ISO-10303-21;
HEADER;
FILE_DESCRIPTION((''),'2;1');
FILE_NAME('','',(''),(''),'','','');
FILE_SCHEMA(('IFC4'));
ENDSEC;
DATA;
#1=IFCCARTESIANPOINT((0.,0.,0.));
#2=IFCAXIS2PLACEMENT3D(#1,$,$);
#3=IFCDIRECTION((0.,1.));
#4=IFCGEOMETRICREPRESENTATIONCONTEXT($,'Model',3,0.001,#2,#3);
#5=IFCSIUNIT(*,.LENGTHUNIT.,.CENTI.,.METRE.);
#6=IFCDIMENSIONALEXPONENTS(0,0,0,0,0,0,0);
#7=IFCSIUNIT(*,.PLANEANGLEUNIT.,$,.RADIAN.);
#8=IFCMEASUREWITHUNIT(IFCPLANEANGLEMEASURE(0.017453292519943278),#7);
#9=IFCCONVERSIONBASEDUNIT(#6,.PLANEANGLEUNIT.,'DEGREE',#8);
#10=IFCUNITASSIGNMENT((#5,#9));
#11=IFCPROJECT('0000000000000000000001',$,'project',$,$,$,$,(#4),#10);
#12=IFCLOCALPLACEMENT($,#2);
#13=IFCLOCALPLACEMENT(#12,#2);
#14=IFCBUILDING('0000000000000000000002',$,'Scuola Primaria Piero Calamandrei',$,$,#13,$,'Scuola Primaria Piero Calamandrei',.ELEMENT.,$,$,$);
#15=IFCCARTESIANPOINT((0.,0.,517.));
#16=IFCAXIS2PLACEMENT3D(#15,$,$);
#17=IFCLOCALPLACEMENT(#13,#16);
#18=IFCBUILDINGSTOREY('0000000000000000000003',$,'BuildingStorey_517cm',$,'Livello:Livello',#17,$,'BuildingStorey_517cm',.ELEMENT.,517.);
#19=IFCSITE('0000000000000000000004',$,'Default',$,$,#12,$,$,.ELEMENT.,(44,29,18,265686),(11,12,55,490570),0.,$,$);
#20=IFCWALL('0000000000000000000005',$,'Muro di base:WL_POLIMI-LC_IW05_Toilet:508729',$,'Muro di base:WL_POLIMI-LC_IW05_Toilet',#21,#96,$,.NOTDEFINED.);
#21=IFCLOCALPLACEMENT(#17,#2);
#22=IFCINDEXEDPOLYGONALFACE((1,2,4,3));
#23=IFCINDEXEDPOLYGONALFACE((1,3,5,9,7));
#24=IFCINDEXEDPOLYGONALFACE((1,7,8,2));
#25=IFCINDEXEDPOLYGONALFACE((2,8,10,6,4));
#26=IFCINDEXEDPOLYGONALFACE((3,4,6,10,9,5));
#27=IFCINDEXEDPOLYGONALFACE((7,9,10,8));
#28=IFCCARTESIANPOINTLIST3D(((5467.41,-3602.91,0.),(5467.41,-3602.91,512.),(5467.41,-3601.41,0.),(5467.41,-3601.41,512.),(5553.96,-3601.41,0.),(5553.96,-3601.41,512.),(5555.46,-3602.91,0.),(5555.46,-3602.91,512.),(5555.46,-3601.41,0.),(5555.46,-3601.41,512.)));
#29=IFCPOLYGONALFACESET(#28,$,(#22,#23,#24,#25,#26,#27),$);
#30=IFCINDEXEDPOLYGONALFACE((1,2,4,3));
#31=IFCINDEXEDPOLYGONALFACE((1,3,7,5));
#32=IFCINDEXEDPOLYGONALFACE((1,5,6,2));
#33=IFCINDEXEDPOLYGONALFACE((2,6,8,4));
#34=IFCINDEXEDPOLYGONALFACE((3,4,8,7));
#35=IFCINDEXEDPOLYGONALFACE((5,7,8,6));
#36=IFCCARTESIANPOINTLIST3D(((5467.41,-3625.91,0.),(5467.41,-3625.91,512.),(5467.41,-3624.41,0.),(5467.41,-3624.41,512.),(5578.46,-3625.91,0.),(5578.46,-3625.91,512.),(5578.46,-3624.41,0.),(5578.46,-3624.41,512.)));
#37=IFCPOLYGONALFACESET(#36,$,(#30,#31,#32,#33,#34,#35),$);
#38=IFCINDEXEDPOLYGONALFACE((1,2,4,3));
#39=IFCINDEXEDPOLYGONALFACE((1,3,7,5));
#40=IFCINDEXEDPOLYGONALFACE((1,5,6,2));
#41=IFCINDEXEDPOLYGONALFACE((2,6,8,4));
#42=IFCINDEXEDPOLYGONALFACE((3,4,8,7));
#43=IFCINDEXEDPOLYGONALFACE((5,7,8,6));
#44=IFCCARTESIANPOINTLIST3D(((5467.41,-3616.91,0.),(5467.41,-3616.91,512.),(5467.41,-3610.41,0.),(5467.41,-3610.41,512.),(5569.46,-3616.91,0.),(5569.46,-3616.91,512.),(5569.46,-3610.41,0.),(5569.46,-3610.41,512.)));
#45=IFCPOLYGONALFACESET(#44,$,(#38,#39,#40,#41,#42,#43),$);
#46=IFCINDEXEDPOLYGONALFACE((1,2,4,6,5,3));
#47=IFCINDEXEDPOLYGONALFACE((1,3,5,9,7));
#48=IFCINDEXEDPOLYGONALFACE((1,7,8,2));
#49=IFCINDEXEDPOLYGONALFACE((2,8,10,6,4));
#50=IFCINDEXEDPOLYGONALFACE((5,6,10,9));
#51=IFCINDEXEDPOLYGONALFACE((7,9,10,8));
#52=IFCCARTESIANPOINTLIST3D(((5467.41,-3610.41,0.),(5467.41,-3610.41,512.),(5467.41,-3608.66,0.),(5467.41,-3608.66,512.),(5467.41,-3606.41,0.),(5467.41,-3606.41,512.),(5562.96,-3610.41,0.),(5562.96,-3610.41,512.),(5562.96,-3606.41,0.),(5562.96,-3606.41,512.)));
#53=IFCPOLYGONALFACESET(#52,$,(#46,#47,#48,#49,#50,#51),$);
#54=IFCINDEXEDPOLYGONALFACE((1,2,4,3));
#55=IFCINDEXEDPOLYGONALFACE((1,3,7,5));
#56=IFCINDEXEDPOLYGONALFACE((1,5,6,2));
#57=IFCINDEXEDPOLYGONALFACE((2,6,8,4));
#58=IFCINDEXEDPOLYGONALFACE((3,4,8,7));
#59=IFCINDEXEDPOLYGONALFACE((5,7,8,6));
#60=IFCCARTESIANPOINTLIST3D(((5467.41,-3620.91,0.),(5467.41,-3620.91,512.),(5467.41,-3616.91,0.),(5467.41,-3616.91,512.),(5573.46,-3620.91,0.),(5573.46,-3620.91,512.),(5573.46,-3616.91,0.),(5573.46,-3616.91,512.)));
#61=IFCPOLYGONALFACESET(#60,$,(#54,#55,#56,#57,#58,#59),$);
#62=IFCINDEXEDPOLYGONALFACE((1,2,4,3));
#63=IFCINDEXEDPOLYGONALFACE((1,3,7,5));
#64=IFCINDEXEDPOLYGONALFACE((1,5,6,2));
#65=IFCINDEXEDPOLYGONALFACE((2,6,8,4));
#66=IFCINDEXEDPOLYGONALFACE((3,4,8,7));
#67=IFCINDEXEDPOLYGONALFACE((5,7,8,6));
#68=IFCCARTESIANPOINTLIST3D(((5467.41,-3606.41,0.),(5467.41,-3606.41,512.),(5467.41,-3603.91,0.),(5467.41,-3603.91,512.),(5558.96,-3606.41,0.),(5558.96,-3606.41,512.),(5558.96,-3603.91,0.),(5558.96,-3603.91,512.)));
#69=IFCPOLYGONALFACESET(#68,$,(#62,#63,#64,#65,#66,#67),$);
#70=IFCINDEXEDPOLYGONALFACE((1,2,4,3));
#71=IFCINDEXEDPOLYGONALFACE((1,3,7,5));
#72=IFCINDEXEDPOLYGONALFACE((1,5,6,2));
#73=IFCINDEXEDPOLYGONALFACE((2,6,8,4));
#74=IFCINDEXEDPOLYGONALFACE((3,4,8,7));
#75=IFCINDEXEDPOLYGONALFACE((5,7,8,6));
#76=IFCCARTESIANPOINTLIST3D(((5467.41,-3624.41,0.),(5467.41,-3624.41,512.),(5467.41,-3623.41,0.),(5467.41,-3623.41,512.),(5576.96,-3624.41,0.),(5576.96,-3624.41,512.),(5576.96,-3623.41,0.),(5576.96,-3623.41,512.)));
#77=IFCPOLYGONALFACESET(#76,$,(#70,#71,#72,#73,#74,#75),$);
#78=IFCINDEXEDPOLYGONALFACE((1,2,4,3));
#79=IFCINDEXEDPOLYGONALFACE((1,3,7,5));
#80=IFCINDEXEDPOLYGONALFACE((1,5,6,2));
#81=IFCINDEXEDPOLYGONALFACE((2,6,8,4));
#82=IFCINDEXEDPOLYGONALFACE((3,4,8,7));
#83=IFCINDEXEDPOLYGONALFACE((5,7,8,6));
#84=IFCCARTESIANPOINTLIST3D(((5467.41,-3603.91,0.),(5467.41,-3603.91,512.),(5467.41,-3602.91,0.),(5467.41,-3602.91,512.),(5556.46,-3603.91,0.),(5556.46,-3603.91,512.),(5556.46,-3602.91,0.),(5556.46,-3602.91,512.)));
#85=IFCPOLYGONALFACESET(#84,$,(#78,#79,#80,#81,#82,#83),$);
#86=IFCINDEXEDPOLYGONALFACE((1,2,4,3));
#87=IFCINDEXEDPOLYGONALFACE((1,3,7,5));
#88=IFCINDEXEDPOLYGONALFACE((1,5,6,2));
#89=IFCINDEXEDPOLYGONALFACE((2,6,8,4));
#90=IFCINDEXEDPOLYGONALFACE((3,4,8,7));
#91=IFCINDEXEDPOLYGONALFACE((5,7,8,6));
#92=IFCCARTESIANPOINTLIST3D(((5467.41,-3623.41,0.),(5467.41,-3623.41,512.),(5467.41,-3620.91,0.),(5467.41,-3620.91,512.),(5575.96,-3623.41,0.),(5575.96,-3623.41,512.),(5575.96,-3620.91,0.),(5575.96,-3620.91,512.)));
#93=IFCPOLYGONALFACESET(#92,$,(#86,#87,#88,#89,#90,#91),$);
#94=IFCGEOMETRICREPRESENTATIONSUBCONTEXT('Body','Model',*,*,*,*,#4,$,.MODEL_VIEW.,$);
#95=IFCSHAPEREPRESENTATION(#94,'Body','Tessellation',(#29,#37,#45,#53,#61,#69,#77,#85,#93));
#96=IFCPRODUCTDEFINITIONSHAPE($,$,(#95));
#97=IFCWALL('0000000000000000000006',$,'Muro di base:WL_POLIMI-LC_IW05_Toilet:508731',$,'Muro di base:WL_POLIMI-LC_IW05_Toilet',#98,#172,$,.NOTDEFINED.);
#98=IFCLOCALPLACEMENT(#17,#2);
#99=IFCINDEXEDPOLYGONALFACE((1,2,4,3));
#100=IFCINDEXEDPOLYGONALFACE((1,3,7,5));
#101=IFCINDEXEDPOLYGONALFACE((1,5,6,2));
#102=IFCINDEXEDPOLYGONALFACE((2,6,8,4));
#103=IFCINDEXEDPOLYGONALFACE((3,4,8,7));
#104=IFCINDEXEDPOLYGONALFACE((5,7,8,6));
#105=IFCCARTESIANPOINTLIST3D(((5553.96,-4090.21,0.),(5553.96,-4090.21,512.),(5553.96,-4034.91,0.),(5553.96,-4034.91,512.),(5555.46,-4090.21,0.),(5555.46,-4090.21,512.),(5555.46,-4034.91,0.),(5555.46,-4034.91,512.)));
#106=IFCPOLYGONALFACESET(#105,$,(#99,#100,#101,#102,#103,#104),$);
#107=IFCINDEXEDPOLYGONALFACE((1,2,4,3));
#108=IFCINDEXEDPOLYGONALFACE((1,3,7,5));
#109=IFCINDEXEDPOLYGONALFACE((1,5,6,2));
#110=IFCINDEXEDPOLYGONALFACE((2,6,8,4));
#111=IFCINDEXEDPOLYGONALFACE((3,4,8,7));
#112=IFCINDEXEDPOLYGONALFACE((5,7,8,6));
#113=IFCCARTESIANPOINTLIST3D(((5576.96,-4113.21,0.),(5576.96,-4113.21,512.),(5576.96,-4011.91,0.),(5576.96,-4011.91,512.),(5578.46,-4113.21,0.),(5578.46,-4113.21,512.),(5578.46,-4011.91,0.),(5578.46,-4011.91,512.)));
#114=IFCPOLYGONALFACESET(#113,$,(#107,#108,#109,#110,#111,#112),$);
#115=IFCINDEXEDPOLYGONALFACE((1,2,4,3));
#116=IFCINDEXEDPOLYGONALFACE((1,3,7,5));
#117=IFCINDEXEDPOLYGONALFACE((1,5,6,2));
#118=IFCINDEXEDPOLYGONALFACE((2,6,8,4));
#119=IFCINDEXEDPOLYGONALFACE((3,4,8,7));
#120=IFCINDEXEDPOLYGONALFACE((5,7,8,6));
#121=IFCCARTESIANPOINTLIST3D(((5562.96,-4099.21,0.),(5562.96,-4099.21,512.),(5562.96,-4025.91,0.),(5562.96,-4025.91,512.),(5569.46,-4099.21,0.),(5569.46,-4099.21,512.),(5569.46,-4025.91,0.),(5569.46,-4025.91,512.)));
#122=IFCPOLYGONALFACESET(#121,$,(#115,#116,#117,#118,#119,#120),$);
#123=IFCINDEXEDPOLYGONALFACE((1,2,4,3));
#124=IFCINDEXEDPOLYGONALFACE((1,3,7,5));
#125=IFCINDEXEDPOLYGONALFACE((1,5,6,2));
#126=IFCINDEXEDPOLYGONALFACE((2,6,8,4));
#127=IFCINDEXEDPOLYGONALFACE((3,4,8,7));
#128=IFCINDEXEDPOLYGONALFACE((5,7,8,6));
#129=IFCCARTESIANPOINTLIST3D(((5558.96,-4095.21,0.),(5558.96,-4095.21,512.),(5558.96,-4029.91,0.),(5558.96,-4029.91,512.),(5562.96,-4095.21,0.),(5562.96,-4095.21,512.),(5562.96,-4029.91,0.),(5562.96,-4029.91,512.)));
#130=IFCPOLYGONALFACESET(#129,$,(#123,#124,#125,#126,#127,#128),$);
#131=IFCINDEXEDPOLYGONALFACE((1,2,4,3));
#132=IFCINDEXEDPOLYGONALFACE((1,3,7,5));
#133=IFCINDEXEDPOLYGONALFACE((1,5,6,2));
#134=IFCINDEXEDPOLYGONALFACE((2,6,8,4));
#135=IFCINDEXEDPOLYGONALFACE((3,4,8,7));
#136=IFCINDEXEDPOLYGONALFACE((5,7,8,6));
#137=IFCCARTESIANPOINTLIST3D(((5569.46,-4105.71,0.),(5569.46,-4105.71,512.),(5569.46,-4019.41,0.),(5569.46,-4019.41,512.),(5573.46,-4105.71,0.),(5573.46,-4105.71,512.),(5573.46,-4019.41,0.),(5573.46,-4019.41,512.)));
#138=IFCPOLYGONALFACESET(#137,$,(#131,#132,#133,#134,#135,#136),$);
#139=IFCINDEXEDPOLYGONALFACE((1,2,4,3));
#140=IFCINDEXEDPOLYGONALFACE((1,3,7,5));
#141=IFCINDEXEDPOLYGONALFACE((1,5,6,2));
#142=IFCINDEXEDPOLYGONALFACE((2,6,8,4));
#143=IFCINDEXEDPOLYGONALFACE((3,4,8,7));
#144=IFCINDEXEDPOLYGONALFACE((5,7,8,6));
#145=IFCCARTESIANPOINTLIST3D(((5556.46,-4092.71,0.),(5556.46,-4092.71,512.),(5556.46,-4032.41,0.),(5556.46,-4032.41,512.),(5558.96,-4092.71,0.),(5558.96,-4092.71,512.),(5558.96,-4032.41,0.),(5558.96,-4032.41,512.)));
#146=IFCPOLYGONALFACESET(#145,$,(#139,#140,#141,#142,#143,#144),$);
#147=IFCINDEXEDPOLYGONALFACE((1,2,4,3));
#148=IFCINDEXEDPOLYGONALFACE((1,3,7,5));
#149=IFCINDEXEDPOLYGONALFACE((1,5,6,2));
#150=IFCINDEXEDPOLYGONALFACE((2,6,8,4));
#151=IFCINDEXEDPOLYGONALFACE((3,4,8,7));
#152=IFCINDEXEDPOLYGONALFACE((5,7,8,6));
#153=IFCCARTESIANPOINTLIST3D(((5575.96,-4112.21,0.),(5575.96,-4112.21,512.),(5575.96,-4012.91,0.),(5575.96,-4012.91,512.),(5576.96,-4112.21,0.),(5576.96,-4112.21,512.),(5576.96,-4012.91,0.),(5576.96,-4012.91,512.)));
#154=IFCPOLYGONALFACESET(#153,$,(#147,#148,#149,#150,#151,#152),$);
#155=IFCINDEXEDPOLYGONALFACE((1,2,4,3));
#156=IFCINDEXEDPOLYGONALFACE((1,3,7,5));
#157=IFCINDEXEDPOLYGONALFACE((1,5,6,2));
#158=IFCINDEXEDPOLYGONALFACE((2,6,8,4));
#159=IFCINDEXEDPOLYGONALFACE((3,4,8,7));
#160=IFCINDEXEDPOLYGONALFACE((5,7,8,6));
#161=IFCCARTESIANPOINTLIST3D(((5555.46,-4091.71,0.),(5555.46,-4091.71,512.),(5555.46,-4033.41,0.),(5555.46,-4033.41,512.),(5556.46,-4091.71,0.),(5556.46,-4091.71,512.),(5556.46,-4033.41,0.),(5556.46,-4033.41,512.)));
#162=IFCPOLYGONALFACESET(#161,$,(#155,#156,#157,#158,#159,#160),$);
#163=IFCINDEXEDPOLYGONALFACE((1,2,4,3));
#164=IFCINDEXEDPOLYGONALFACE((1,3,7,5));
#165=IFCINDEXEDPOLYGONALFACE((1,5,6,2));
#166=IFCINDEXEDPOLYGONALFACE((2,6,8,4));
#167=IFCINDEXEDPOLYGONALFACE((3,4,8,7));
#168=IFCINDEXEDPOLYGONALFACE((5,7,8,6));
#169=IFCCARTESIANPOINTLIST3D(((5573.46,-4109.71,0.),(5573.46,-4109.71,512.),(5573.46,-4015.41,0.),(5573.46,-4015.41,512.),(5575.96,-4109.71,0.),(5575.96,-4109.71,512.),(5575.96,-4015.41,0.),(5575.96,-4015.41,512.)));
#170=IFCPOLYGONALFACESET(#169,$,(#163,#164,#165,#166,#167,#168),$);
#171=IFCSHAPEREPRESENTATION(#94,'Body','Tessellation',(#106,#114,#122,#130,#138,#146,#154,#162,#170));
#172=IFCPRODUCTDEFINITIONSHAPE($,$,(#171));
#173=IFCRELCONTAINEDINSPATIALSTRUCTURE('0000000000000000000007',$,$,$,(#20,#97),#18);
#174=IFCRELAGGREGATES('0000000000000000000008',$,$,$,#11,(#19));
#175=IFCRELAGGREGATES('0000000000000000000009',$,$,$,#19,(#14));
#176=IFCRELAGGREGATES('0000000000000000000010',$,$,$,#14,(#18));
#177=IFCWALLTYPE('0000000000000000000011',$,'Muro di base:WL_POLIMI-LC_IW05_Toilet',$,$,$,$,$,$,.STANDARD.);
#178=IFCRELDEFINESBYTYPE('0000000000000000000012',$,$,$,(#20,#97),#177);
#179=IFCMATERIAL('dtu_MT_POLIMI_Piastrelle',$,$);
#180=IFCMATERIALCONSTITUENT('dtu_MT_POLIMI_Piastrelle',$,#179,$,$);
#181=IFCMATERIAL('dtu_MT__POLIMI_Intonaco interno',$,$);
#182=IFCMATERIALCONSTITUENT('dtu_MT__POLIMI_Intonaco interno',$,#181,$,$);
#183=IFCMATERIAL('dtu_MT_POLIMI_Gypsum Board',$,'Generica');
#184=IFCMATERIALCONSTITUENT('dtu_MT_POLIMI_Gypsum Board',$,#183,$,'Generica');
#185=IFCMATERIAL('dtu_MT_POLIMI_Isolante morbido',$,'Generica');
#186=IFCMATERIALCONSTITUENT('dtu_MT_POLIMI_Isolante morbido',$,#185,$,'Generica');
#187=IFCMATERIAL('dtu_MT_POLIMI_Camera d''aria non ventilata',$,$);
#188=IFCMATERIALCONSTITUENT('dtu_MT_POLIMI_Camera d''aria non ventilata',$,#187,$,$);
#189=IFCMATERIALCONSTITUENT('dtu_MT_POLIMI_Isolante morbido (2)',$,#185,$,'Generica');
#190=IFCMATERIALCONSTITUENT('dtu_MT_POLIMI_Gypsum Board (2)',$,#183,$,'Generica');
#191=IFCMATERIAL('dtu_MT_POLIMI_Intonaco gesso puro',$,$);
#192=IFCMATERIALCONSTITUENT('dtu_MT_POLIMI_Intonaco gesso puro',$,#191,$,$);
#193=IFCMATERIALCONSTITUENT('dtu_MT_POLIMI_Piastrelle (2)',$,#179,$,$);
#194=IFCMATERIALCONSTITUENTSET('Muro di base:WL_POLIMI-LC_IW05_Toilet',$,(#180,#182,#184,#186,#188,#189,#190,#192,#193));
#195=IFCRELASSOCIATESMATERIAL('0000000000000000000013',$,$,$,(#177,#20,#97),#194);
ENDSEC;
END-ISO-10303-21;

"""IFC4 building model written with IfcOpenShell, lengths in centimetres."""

from ifc_helpers import new_model, entity, si_unit, converted_unit, direction, frame, origin, place, context, subcontext, project, spatial, indexed_curve, outline, extrude, material, constituent, constituent_set, type_object, element, save


model = new_model("IFC4")

# Units and contexts
model_context = context("Model", 3, precision=0.001, world=origin(), true_north=direction((0.0, 1.0)))
body_context = subcontext(model_context, "Body", "Model", "MODEL_VIEW")
ifc_project = project(units=[si_unit("LENGTHUNIT", "METRE", prefix="CENTI"), converted_unit("PLANEANGLEUNIT", "DEGREE", entity("IfcPlaneAngleMeasure", 0.017453292519943278), si_unit("PLANEANGLEUNIT", "RADIAN"), dimensions=[0, 0, 0, 0, 0, 0, 0])], contexts=[model_context])

# Site, building, storey
site_placement = place(None, origin())
site = spatial("IfcSite", under=ifc_project, at=site_placement, Name="Default", CompositionType="ELEMENT", RefLatitude=(44, 29, 18, 265686), RefLongitude=(11, 12, 55, 490570), RefElevation=0.0)
building_placement = place(site_placement, origin())
building = spatial("IfcBuilding", under=site, at=building_placement, Name="Scuola Primaria Piero Calamandrei", LongName="Scuola Primaria Piero Calamandrei", CompositionType="ELEMENT")
storey_placement = place(building_placement, frame((0.0, 0.0, 517.0)))
storey = spatial("IfcBuildingStorey", under=building, at=storey_placement, Name="BuildingStorey_517cm", ObjectType="Livello:Livello", LongName="BuildingStorey_517cm", CompositionType="ELEMENT", Elevation=517.0)

# Shared definitions
ifc_material_1 = material(Name="dtu_MT_POLIMI_Isolante morbido", Category="Generica")
ifc_material_2 = material(Name="dtu_MT_POLIMI_Gypsum Board", Category="Generica")
ifc_material_3 = material(Name="dtu_MT__POLIMI_Intonaco interno")

# Shared definitions
ifc_material_4 = material(Name="dtu_MT_POLIMI_Camera d'aria non ventilata")
ifc_material_5 = material(Name="dtu_MT_POLIMI_Intonaco gesso puro")

# Walls
ifc_material_6 = material(Name="dtu_MT_POLIMI_Piastrelle")
ifc_constituent_1 = constituent(ifc_material_6, Name="dtu_MT_POLIMI_Piastrelle")
ifc_constituent_2 = constituent(ifc_material_3, Name="dtu_MT__POLIMI_Intonaco interno")
ifc_constituent_3 = constituent(ifc_material_2, Name="dtu_MT_POLIMI_Gypsum Board", Category="Generica")
ifc_constituent_4 = constituent(ifc_material_1, Name="dtu_MT_POLIMI_Isolante morbido", Category="Generica")
ifc_constituent_5 = constituent(ifc_material_4, Name="dtu_MT_POLIMI_Camera d'aria non ventilata")
ifc_constituent_6 = constituent(ifc_material_1, Name="dtu_MT_POLIMI_Isolante morbido (2)", Category="Generica")
ifc_constituent_7 = constituent(ifc_material_2, Name="dtu_MT_POLIMI_Gypsum Board (2)", Category="Generica")
ifc_constituent_8 = constituent(ifc_material_5, Name="dtu_MT_POLIMI_Intonaco gesso puro")
ifc_constituent_9 = constituent(ifc_material_6, Name="dtu_MT_POLIMI_Piastrelle (2)")
ifc_constituent_set_1 = constituent_set(constituents=[ifc_constituent_1, ifc_constituent_2, ifc_constituent_3, ifc_constituent_4, ifc_constituent_5, ifc_constituent_6, ifc_constituent_7, ifc_constituent_8, ifc_constituent_9], Name="Muro di base:WL_POLIMI-LC_IW05_Toilet")
wall_type_1 = type_object("IfcWallType", Name="Muro di base:WL_POLIMI-LC_IW05_Toilet", PredefinedType="STANDARD", material=ifc_constituent_set_1)
wall_1_placement = place(storey_placement, frame((5467.41, -3613.66, 0.0)))
element("IfcWall", 1, at=wall_1_placement, inside=storey, type_object=wall_type_1, material=ifc_constituent_set_1, Name="Muro di base:WL_POLIMI-LC_IW05_Toilet:508729", ObjectType="Muro di base:WL_POLIMI-LC_IW05_Toilet", PredefinedType="NOTDEFINED", context=body_context, shape_type="SweptSolid", body=[
    extrude(outline(indexed_curve([(-34.02, -0.6), (52.53, -0.6), (52.53, 0.9), (-35.52, 0.9), (-35.52, -0.6), (-34.02, -0.6)], self_intersect=False)), frame((52.53, 11.65, 0.0), z_axis=(0.0, 0.0, 1.0), x_axis=(-1.0, 0.0, 0.0)), (0.0, 0.0, 1.0), 512.0),
    extrude(outline(indexed_curve([(-0.75, -55.53), (0.75, -55.53), (0.75, 55.53), (-0.75, 55.53), (-0.75, -55.53)], self_intersect=False)), frame((55.53, -11.5, 0.0), z_axis=(0.0, 0.0, 1.0), x_axis=(0.0, 1.0, 0.0)), (0.0, 0.0, 1.0), 512.0),
    extrude(outline(indexed_curve([(-51.03, -3.25), (51.03, -3.25), (51.03, 3.25), (-51.03, 3.25), (-51.03, -3.25)], self_intersect=False)), frame((51.03, 0.0, 0.0)), (0.0, 0.0, 1.0), 512.0),
    extrude(outline(indexed_curve([(-38.22, -1.95), (57.33, -1.95), (57.33, 2.05), (-38.22, 2.05), (-38.22, -0.2), (-38.22, -1.95)], self_intersect=False)), frame((38.22, 5.2, 0.0)), (0.0, 0.0, 1.0), 512.0),
    extrude(outline(indexed_curve([(-53.03, -2.0), (53.03, -2.0), (53.03, 2.0), (-53.03, 2.0), (-53.03, -2.0)], self_intersect=False)), frame((53.03, -5.25, 0.0)), (0.0, 0.0, 1.0), 512.0),
    extrude(outline(indexed_curve([(-45.78, -1.25), (45.78, -1.25), (45.78, 1.25), (-45.78, 1.25), (-45.78, -1.25)], self_intersect=False)), frame((45.78, 8.5, 0.0)), (0.0, 0.0, 1.0), 512.0),
    extrude(outline(indexed_curve([(-54.78, -0.5), (54.78, -0.5), (54.78, 0.5), (-54.78, 0.5), (-54.78, -0.5)], self_intersect=False)), frame((54.78, -10.25, 0.0)), (0.0, 0.0, 1.0), 512.0),
    extrude(outline(indexed_curve([(-44.53, -0.5), (44.53, -0.5), (44.53, 0.5), (-44.53, 0.5), (-44.53, -0.5)], self_intersect=False)), frame((44.53, 10.25, 0.0)), (0.0, 0.0, 1.0), 512.0),
    extrude(outline(indexed_curve([(-54.28, -1.25), (54.28, -1.25), (54.28, 1.25), (-54.28, 1.25), (-54.28, -1.25)], self_intersect=False)), frame((54.28, -8.5, 0.0)), (0.0, 0.0, 1.0), 512.0),
])
wall_2_placement = place(storey_placement, frame((5566.21, -4090.21, 0.0), z_axis=(0.0, 0.0, 1.0), x_axis=(0.0, 1.0, 0.0)))
element("IfcWall", 2, at=wall_2_placement, inside=storey, type_object=wall_type_1, material=ifc_constituent_set_1, Name="Muro di base:WL_POLIMI-LC_IW05_Toilet:508731", ObjectType="Muro di base:WL_POLIMI-LC_IW05_Toilet", PredefinedType="NOTDEFINED", context=body_context, shape_type="SweptSolid", body=[
    extrude(outline(indexed_curve([(-0.75, -27.65), (0.75, -27.65), (0.75, 27.65), (-0.75, 27.65), (-0.75, -27.65)], self_intersect=False)), frame((27.65, 11.5, 0.0), z_axis=(0.0, 0.0, 1.0), x_axis=(0.0, -1.0, 0.0)), (0.0, 0.0, 1.0), 512.0),
    extrude(outline(indexed_curve([(-0.75, -50.65), (0.75, -50.65), (0.75, 50.65), (-0.75, 50.65), (-0.75, -50.65)], self_intersect=False)), frame((27.65, -11.5, 0.0), z_axis=(0.0, 0.0, 1.0), x_axis=(0.0, 1.0, 0.0)), (0.0, 0.0, 1.0), 512.0),
    extrude(outline(indexed_curve([(-36.65, -3.25), (36.65, -3.25), (36.65, 3.25), (-36.65, 3.25), (-36.65, -3.25)], self_intersect=False)), frame((27.65, 0.0, 0.0)), (0.0, 0.0, 1.0), 512.0),
    extrude(outline(indexed_curve([(-32.65, -2.0), (32.65, -2.0), (32.65, 2.0), (-32.65, 2.0), (-32.65, -2.0)], self_intersect=False)), frame((27.65, 5.25, 0.0)), (0.0, 0.0, 1.0), 512.0),
    extrude(outline(indexed_curve([(-43.15, -2.0), (43.15, -2.0), (43.15, 2.0), (-43.15, 2.0), (-43.15, -2.0)], self_intersect=False)), frame((27.65, -5.25, 0.0)), (0.0, 0.0, 1.0), 512.0),
    extrude(outline(indexed_curve([(-30.15, -1.25), (30.15, -1.25), (30.15, 1.25), (-30.15, 1.25), (-30.15, -1.25)], self_intersect=False)), frame((27.65, 8.5, 0.0)), (0.0, 0.0, 1.0), 512.0),
    extrude(outline(indexed_curve([(-49.65, -0.5), (49.65, -0.5), (49.65, 0.5), (-49.65, 0.5), (-49.65, -0.5)], self_intersect=False)), frame((27.65, -10.25, 0.0)), (0.0, 0.0, 1.0), 512.0),
    extrude(outline(indexed_curve([(-29.15, -0.5), (29.15, -0.5), (29.15, 0.5), (-29.15, 0.5), (-29.15, -0.5)], self_intersect=False)), frame((27.65, 10.25, 0.0)), (0.0, 0.0, 1.0), 512.0),
    extrude(outline(indexed_curve([(-47.15, -1.25), (47.15, -1.25), (47.15, 1.25), (-47.15, 1.25), (-47.15, -1.25)], self_intersect=False)), frame((27.65, -8.5, 0.0)), (0.0, 0.0, 1.0), 512.0),
])

save(model, "model.ifc")
